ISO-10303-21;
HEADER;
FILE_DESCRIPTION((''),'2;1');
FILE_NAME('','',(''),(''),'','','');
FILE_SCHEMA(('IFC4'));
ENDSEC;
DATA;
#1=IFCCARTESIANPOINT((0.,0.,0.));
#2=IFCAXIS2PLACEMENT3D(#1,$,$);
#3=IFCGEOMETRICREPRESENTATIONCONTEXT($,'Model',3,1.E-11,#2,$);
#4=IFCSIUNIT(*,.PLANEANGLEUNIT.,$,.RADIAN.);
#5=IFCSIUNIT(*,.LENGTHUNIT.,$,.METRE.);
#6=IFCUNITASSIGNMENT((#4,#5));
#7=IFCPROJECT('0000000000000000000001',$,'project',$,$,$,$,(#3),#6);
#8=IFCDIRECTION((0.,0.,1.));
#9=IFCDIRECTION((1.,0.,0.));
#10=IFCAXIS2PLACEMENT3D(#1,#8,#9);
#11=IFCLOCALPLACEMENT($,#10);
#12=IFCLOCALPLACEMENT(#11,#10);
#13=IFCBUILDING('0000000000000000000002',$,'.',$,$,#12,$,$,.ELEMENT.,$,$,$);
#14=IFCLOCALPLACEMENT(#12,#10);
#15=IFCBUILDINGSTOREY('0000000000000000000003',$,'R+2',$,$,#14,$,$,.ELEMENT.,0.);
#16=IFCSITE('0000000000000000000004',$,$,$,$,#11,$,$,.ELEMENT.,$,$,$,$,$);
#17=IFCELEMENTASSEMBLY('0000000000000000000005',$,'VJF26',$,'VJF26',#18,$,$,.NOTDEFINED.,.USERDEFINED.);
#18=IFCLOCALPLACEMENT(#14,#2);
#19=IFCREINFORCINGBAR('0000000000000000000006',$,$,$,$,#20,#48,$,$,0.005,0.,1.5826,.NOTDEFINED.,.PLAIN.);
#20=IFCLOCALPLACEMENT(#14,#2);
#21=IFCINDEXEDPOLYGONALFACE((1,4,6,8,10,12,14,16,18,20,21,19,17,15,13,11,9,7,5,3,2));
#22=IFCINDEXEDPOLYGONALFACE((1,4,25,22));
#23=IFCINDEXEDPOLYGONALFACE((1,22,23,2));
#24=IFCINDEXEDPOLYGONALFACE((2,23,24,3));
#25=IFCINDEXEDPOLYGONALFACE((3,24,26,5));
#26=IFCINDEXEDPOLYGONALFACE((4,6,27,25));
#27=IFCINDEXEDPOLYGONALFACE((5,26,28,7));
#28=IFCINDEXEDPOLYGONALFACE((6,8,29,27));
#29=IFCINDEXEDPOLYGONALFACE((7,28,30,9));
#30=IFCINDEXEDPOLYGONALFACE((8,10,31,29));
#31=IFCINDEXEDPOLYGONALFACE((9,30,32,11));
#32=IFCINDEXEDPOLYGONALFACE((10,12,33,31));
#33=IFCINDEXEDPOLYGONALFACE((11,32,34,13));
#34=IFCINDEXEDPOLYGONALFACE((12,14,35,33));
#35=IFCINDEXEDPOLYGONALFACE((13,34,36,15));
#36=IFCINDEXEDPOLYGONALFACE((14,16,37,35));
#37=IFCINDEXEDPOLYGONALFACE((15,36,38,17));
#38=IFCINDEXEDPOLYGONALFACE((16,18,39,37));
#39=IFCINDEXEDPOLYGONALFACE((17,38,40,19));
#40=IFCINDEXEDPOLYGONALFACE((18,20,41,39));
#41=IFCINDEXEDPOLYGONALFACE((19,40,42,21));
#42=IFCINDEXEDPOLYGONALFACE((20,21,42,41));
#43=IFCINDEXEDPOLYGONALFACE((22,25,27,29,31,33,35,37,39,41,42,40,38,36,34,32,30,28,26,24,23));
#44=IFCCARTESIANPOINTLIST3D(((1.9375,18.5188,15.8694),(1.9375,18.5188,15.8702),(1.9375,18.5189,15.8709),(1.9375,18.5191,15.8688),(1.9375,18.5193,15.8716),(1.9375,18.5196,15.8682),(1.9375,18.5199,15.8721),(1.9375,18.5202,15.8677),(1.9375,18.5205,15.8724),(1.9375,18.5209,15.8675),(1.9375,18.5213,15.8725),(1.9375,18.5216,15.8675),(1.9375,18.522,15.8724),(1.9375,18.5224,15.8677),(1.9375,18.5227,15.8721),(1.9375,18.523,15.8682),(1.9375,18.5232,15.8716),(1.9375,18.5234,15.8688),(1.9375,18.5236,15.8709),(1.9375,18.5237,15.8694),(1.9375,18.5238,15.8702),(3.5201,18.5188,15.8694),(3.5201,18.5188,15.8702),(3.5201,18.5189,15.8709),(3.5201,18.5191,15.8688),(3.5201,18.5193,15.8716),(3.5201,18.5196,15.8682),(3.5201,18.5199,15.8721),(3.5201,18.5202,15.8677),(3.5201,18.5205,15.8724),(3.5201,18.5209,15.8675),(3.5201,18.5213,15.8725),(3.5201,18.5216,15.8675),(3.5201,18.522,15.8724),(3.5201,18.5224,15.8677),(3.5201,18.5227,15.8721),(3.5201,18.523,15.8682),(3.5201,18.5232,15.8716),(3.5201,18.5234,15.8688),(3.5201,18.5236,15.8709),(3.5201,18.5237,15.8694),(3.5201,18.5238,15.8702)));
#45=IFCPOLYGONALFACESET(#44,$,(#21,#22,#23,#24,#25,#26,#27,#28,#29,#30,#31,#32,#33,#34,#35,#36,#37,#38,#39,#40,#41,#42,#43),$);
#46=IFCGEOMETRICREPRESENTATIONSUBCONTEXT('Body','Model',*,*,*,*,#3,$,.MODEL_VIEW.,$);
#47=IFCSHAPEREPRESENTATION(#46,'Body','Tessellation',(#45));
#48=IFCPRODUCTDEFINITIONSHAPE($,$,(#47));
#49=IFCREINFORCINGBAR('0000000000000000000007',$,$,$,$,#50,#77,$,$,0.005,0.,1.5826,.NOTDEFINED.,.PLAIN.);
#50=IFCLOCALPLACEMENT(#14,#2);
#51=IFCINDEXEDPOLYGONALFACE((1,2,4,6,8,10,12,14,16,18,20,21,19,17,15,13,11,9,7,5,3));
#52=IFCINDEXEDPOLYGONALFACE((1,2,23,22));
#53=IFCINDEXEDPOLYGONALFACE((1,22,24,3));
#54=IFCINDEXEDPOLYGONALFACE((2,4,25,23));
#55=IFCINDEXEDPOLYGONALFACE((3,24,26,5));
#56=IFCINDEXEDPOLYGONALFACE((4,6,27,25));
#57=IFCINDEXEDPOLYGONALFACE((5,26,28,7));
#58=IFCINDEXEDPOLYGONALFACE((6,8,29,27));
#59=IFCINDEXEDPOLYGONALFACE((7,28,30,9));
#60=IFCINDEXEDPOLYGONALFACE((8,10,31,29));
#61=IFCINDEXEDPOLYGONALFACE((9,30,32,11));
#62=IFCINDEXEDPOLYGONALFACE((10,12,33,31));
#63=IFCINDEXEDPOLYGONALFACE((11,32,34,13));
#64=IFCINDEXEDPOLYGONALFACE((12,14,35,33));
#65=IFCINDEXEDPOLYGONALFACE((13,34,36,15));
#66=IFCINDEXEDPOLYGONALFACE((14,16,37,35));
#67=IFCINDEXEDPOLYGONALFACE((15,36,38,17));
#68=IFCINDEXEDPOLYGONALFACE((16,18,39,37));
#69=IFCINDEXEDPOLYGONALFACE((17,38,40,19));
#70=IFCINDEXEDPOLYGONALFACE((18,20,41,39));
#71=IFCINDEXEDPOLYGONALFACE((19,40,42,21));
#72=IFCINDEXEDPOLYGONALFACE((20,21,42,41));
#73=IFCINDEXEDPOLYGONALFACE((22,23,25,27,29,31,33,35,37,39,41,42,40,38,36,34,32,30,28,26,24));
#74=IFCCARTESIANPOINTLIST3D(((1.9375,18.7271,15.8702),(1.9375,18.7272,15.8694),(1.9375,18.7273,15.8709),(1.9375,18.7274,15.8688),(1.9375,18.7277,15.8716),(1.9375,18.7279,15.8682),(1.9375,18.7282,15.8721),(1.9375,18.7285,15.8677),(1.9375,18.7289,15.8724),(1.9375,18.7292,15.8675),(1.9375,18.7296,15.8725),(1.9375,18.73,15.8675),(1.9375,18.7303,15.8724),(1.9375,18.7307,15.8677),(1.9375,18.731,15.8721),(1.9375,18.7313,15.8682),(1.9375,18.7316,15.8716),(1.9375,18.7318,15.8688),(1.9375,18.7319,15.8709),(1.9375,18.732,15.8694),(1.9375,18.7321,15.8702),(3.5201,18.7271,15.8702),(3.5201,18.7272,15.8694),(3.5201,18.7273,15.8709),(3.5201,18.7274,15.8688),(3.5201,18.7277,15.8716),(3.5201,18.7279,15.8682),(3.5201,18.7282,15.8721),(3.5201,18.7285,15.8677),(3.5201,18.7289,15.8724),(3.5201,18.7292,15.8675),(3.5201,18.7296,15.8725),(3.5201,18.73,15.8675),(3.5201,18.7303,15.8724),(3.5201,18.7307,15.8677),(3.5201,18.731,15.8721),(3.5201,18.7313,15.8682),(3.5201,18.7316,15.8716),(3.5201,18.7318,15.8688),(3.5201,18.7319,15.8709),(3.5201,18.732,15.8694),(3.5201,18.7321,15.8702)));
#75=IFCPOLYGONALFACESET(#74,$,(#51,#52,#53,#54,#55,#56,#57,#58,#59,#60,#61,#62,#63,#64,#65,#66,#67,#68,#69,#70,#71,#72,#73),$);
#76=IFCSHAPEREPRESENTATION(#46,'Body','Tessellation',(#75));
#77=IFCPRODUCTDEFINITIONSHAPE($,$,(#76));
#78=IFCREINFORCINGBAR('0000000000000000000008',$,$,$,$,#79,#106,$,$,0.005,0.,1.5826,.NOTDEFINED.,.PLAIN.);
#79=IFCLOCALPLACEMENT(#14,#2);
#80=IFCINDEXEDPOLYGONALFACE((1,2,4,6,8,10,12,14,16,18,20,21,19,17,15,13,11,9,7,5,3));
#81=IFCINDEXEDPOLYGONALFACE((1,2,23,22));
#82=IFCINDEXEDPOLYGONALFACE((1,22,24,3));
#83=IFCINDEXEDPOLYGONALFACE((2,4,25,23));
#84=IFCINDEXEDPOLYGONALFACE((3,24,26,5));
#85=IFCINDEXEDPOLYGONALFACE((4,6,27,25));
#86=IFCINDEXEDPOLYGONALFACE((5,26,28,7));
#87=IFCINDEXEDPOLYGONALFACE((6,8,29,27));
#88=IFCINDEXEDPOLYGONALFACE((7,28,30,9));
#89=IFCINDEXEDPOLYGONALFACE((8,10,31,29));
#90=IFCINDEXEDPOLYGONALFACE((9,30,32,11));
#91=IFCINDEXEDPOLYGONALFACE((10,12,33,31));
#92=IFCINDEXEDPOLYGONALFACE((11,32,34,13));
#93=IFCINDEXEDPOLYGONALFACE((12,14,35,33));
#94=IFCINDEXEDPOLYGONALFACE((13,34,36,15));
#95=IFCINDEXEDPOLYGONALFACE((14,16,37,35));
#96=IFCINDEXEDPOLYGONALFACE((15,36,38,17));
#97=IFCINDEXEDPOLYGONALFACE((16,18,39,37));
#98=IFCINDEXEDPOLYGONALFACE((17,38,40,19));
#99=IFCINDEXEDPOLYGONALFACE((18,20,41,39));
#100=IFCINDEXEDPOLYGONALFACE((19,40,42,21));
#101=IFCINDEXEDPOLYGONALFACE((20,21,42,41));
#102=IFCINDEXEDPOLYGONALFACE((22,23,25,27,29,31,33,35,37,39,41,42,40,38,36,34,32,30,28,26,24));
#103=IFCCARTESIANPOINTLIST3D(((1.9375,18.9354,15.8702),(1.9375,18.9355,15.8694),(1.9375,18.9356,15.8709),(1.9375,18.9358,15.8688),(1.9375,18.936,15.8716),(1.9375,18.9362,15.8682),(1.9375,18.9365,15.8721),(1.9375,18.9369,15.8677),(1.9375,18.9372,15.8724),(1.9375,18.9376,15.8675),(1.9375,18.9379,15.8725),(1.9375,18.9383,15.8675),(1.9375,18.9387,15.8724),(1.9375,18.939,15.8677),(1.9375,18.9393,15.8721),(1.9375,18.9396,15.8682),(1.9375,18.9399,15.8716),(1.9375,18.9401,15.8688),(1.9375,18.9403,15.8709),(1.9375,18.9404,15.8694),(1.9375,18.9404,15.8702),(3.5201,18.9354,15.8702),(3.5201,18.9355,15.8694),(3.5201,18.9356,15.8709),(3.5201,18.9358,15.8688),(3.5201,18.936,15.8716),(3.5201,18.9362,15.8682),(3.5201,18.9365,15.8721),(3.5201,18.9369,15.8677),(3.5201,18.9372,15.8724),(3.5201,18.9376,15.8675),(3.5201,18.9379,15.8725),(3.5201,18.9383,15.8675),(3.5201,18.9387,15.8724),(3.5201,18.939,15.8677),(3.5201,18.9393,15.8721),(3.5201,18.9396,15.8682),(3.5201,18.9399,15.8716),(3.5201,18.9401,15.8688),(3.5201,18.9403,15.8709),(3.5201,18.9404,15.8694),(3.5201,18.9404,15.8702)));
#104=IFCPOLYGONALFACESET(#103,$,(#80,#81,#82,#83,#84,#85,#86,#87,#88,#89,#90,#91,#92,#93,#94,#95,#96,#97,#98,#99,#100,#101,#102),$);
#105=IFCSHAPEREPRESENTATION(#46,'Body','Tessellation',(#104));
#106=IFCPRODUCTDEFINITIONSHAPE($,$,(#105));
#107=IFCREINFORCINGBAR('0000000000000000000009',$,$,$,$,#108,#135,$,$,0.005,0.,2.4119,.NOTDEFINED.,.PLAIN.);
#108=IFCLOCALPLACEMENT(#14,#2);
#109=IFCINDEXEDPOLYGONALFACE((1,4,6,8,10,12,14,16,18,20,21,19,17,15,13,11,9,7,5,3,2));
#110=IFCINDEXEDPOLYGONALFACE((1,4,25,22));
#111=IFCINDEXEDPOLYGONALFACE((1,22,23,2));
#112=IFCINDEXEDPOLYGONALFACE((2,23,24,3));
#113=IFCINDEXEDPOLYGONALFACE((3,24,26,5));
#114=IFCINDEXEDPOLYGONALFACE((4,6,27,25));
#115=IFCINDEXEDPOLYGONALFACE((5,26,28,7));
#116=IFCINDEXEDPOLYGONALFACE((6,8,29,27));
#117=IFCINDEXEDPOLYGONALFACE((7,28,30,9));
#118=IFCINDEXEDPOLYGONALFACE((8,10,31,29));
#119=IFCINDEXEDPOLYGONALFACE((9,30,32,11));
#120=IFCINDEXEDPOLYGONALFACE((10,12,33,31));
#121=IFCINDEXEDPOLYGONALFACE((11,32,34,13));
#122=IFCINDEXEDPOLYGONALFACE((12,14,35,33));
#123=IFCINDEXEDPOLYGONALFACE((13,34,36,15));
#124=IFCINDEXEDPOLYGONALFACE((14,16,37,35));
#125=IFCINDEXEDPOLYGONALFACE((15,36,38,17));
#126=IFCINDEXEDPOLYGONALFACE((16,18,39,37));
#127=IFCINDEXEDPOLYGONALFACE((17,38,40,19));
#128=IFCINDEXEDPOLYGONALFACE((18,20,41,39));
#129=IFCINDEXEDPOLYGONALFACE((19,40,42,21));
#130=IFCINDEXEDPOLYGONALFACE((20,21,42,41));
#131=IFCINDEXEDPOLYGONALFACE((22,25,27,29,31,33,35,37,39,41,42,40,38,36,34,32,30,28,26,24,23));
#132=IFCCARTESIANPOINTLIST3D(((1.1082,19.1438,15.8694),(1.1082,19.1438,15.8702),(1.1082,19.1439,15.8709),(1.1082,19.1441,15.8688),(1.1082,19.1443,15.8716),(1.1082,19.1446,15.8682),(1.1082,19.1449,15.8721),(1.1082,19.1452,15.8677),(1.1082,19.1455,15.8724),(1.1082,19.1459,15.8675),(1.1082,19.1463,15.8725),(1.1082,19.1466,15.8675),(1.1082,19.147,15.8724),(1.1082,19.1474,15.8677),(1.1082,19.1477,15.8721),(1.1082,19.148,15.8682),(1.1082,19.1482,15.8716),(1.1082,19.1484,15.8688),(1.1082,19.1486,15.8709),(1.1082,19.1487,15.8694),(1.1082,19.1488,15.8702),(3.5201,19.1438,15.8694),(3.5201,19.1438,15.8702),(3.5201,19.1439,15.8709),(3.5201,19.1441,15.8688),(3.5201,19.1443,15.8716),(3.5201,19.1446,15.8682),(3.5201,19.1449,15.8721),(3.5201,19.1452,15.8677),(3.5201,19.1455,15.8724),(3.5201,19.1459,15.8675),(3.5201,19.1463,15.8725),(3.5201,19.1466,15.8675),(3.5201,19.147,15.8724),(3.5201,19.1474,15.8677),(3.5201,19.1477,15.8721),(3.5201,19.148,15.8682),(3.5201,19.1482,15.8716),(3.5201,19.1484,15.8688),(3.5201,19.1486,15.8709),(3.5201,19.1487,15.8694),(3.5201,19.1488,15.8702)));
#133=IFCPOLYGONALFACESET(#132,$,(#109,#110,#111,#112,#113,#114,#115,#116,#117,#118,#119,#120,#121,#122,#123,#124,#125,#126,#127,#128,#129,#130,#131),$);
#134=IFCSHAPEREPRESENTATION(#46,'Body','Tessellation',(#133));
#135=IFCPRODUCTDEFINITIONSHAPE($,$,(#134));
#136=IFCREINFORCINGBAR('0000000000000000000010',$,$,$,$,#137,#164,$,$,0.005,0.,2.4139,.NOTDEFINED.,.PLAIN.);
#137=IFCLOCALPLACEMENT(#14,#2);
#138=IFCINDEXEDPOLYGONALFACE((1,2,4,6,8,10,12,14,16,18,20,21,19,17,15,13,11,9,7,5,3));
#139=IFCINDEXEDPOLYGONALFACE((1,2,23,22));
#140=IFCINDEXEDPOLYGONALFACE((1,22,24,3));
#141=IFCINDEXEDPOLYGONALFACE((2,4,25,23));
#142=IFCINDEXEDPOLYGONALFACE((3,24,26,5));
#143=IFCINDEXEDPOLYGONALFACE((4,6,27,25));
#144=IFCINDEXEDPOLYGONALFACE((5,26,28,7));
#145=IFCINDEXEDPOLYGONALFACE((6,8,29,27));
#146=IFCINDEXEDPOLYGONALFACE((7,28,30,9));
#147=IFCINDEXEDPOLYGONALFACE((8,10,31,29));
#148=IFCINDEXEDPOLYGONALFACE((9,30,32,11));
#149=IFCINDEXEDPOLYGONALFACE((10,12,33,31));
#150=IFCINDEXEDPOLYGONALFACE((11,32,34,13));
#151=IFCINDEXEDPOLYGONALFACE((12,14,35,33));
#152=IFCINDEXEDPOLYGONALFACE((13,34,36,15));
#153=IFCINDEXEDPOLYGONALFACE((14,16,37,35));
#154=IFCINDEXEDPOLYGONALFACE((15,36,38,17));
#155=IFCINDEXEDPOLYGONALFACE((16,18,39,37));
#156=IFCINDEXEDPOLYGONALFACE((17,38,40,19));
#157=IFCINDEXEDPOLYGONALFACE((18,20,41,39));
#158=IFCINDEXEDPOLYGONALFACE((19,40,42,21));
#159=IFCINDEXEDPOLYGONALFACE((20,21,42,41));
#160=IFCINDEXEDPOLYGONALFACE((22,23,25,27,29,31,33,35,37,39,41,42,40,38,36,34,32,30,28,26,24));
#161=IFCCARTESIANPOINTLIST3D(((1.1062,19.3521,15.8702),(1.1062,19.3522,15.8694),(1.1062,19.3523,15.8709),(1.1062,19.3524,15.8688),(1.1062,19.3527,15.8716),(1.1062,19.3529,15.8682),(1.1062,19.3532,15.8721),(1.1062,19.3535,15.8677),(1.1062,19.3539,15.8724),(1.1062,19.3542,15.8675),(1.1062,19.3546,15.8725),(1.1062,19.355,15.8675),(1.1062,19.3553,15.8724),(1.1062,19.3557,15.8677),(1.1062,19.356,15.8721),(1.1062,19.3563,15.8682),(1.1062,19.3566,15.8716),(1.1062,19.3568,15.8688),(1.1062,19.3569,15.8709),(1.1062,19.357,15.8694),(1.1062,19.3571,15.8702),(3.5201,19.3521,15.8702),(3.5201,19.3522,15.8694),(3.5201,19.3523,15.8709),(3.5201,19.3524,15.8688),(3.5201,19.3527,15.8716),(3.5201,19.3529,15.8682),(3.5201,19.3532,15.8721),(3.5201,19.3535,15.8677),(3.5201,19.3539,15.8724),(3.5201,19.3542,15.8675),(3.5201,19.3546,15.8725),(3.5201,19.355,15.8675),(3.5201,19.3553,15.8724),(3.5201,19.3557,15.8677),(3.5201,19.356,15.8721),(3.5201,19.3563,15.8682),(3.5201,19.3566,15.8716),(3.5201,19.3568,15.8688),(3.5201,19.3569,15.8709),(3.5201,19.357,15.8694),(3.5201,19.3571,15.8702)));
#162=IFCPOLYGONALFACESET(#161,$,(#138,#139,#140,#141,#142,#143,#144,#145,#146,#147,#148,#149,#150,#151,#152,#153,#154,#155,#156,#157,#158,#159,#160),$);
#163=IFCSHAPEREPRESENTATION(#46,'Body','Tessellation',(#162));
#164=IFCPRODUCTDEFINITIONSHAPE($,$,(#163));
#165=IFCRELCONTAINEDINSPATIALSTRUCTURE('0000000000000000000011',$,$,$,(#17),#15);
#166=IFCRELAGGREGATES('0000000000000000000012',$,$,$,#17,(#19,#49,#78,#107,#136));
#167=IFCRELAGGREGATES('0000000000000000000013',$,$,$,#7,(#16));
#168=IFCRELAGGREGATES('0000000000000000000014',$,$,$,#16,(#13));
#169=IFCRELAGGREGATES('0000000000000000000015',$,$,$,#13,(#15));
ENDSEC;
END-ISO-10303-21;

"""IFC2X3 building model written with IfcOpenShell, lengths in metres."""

from ifc_helpers import new_model, entity, si_unit, origin, origin_with_axes, place, context, subcontext, project, spatial, shape, element, aggregate, save


model = new_model("IFC2X3")

# Units and contexts
model_context = context("Model", 3, precision=1e-11, world=origin())
body_context = subcontext(model_context, "Body", "Model", "MODEL_VIEW")
ifc_project = project(units=[si_unit("PLANEANGLEUNIT", "RADIAN"), si_unit("LENGTHUNIT", "METRE")], contexts=[model_context])

# Site, building, storey
site_placement = place(None, origin_with_axes())
site = spatial("IfcSite", under=ifc_project, at=site_placement, CompositionType="ELEMENT")
building_placement = place(site_placement, origin_with_axes())
building = spatial("IfcBuilding", under=site, at=building_placement, Name=".", CompositionType="ELEMENT")
storey_placement = place(building_placement, origin_with_axes())
storey = spatial("IfcBuildingStorey", under=building, at=storey_placement, Name="R+2", CompositionType="ELEMENT", Elevation=0.0)

# Element assembly, reinforcing bars
assembly_1_placement = place(storey_placement, origin_with_axes())
assembly_1 = element("IfcElementAssembly", 1, at=assembly_1_placement, inside=storey, Name="VJF26", ObjectType="VJF26", AssemblyPlace="NOTDEFINED", PredefinedType="USERDEFINED")
reinforcing_bar_1_placement = place(assembly_1_placement, origin_with_axes())
reinforcing_bar_1 = element("IfcReinforcingBar", 2, at=reinforcing_bar_1_placement, BarLength=1.5826, BarRole="NOTDEFINED", BarSurface="PLAIN", CrossSectionArea=0.0, NominalDiameter=0.005, shapes=[
    shape(body_context, "Body", "AdvancedSweptSolid", [entity("IfcSweptDiskSolid", entity("IfcPolyline", [entity("IfcCartesianPoint", [1.9375, 18.5213, 15.87]), entity("IfcCartesianPoint", [3.5201, 18.5213, 15.87])]), 0.0025, None, 0.0, 1.5826)]),
    shape(body_context, "Body", "AdvancedSweptSolid", [entity("IfcSweptDiskSolid", entity("IfcPolyline", [entity("IfcCartesianPoint", [1.9375, 18.5213, 15.87]), entity("IfcCartesianPoint", [3.5201, 18.5213, 15.87])]), 0.0025, None, 0.0, 1.5826)]),
])
reinforcing_bar_2_placement = place(assembly_1_placement, origin_with_axes())
reinforcing_bar_2 = element("IfcReinforcingBar", 3, at=reinforcing_bar_2_placement, BarLength=1.5826, BarRole="NOTDEFINED", BarSurface="PLAIN", CrossSectionArea=0.0, NominalDiameter=0.005, shapes=[
    shape(body_context, "Body", "AdvancedSweptSolid", [entity("IfcSweptDiskSolid", entity("IfcPolyline", [entity("IfcCartesianPoint", [1.9375, 18.7296, 15.87]), entity("IfcCartesianPoint", [3.5201, 18.7296, 15.87])]), 0.0025, None, 0.0, 1.5826)]),
    shape(body_context, "Body", "AdvancedSweptSolid", [entity("IfcSweptDiskSolid", entity("IfcPolyline", [entity("IfcCartesianPoint", [1.9375, 18.7296, 15.87]), entity("IfcCartesianPoint", [3.5201, 18.7296, 15.87])]), 0.0025, None, 0.0, 1.5826)]),
])
reinforcing_bar_3_placement = place(assembly_1_placement, origin_with_axes())
reinforcing_bar_3 = element("IfcReinforcingBar", 4, at=reinforcing_bar_3_placement, BarLength=1.5826, BarRole="NOTDEFINED", BarSurface="PLAIN", CrossSectionArea=0.0, NominalDiameter=0.005, shapes=[
    shape(body_context, "Body", "AdvancedSweptSolid", [entity("IfcSweptDiskSolid", entity("IfcPolyline", [entity("IfcCartesianPoint", [1.9375, 18.9379, 15.87]), entity("IfcCartesianPoint", [3.5201, 18.9379, 15.87])]), 0.0025, None, 0.0, 1.5826)]),
    shape(body_context, "Body", "AdvancedSweptSolid", [entity("IfcSweptDiskSolid", entity("IfcPolyline", [entity("IfcCartesianPoint", [1.9375, 18.9379, 15.87]), entity("IfcCartesianPoint", [3.5201, 18.9379, 15.87])]), 0.0025, None, 0.0, 1.5826)]),
])
reinforcing_bar_4_placement = place(assembly_1_placement, origin_with_axes())
reinforcing_bar_4 = element("IfcReinforcingBar", 5, at=reinforcing_bar_4_placement, BarLength=2.4119, BarRole="NOTDEFINED", BarSurface="PLAIN", CrossSectionArea=0.0, NominalDiameter=0.005, shapes=[
    shape(body_context, "Body", "AdvancedSweptSolid", [entity("IfcSweptDiskSolid", entity("IfcPolyline", [entity("IfcCartesianPoint", [1.1082, 19.1463, 15.87]), entity("IfcCartesianPoint", [3.5201, 19.1463, 15.87])]), 0.0025, None, 0.0, 2.4119)]),
    shape(body_context, "Body", "AdvancedSweptSolid", [entity("IfcSweptDiskSolid", entity("IfcPolyline", [entity("IfcCartesianPoint", [1.1082, 19.1463, 15.87]), entity("IfcCartesianPoint", [3.5201, 19.1463, 15.87])]), 0.0025, None, 0.0, 2.4119)]),
])
reinforcing_bar_5_placement = place(assembly_1_placement, origin_with_axes())
reinforcing_bar_5 = element("IfcReinforcingBar", 6, at=reinforcing_bar_5_placement, BarLength=2.4139, BarRole="NOTDEFINED", BarSurface="PLAIN", CrossSectionArea=0.0, NominalDiameter=0.005, shapes=[
    shape(body_context, "Body", "AdvancedSweptSolid", [entity("IfcSweptDiskSolid", entity("IfcPolyline", [entity("IfcCartesianPoint", [1.1062, 19.3546, 15.87]), entity("IfcCartesianPoint", [3.5201, 19.3546, 15.87])]), 0.0025, None, 0.0, 2.4139)]),
    shape(body_context, "Body", "AdvancedSweptSolid", [entity("IfcSweptDiskSolid", entity("IfcPolyline", [entity("IfcCartesianPoint", [1.1062, 19.3546, 15.87]), entity("IfcCartesianPoint", [3.5201, 19.3546, 15.87])]), 0.0025, None, 0.0, 2.4139)]),
])
aggregate(assembly_1, [reinforcing_bar_1, reinforcing_bar_2, reinforcing_bar_3, reinforcing_bar_4, reinforcing_bar_5])

save(model, "model.ifc")
